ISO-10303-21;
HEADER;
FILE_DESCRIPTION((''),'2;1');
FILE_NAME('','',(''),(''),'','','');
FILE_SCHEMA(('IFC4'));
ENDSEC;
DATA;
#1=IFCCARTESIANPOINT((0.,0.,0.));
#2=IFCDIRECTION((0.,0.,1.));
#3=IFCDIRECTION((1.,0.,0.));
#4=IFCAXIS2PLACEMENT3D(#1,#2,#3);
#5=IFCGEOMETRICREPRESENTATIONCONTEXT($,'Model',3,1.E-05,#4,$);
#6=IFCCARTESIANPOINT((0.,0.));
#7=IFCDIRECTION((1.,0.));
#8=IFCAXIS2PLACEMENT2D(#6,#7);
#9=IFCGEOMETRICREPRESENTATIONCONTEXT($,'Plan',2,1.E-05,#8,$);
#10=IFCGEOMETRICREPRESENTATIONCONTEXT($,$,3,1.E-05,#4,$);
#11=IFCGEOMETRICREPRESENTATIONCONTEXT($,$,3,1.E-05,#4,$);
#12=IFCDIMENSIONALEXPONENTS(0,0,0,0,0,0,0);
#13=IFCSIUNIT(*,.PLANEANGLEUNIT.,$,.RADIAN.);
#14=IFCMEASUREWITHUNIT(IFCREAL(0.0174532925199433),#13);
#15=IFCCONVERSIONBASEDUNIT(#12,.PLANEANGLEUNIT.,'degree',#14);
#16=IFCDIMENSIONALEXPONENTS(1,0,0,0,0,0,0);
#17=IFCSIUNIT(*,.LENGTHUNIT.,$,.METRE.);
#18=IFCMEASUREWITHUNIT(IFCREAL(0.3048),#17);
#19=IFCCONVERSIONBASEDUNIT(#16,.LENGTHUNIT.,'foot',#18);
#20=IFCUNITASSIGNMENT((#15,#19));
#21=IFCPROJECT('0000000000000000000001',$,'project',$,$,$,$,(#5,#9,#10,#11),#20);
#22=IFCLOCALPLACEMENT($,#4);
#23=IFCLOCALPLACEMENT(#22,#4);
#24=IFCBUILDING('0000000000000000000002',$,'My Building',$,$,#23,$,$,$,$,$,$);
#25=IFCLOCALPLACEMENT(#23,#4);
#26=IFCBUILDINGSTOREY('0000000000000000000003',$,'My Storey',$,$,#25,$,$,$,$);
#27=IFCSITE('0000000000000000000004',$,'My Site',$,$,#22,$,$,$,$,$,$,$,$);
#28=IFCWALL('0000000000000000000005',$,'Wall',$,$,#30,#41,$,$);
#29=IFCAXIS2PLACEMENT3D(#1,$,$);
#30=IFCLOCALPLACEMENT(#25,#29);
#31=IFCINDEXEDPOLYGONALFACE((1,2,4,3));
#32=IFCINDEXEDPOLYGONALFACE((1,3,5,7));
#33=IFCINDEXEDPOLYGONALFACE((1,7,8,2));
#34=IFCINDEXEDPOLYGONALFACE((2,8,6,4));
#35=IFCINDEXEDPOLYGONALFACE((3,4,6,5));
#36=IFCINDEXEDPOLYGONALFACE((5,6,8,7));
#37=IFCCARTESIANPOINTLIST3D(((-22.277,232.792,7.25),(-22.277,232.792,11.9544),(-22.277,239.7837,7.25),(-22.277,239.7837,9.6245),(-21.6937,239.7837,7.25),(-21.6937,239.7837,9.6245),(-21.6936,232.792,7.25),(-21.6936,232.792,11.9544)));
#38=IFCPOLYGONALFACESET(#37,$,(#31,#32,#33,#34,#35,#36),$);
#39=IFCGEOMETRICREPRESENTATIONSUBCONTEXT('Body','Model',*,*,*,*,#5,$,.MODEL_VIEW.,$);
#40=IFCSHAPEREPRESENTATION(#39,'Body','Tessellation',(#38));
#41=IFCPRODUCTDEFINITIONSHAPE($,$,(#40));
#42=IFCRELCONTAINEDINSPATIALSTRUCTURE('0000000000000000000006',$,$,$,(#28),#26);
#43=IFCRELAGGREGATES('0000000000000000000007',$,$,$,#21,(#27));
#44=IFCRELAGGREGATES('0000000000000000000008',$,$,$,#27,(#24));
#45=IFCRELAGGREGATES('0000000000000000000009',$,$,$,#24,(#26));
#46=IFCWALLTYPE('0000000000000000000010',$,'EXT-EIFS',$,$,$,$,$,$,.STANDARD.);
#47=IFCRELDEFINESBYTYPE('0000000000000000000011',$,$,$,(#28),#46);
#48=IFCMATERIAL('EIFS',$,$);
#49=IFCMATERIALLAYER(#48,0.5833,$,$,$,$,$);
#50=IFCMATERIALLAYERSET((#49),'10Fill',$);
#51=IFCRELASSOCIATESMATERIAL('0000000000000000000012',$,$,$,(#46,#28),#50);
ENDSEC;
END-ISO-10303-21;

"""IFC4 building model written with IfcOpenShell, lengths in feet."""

from ifc_helpers import new_model, entity, si_unit, converted_unit, frame, origin_with_axes, origin_2d_with_axis, place, context, subcontext, project, spatial, indexed_curve, outline, extrude, clip, halfspace, material, layer, layer_set, layer_usage, type_object, element, save


model = new_model("IFC4")

# Units and contexts
model_context = context("Model", 3, precision=1e-05, world=origin_with_axes())
plan_context = context("Plan", 2, precision=1e-05, world=origin_2d_with_axis())
context_of_model_1 = context(None, 3, precision=1e-05, world=origin_with_axes())
context_of_model_2 = context(None, 3, precision=1e-05, world=origin_with_axes())
body_context = subcontext(model_context, "Body", "Model", "MODEL_VIEW")
ifc_project = project(units=[converted_unit("PLANEANGLEUNIT", "degree", entity("IfcReal", 0.0174532925199433), si_unit("PLANEANGLEUNIT", "RADIAN"), dimensions=[0, 0, 0, 0, 0, 0, 0]), converted_unit("LENGTHUNIT", "foot", entity("IfcReal", 0.3048), si_unit("LENGTHUNIT", "METRE"), dimensions=[1, 0, 0, 0, 0, 0, 0])], contexts=[model_context, plan_context, context_of_model_1, context_of_model_2])

# Site, building, storey
site_placement = place(None, origin_with_axes())
site = spatial("IfcSite", under=ifc_project, at=site_placement, Name="My Site")
building_placement = place(site_placement, origin_with_axes())
building = spatial("IfcBuilding", under=site, at=building_placement, Name="My Building")
storey_placement = place(building_placement, origin_with_axes())
storey = spatial("IfcBuildingStorey", under=building, at=storey_placement, Name="My Storey")

# Wall
ifc_material_1 = material(Name="EIFS")
ifc_layer_1 = layer(ifc_material_1, 0.5833)
ifc_layer_set_1 = layer_set([ifc_layer_1], Name="10Fill")
ifc_layer_usage_1 = layer_usage(ifc_layer_set_1, "AXIS2", "POSITIVE", 0.0)
wall_type_1 = type_object("IfcWallType", Name="EXT-EIFS", PredefinedType="STANDARD", material=ifc_layer_set_1)
wall_1_placement = place(storey_placement, frame((-22.277, 239.7837, 7.25), z_axis=(0.0, 0.0, 1.0), x_axis=(0.000001, -1.0, 0.0)))
element("IfcWall", 1, at=wall_1_placement, inside=storey, type_object=wall_type_1, material=ifc_layer_usage_1, Name="Wall", context=body_context, shape_type="Clipping", body=[
    clip(extrude(outline(indexed_curve([(0.0, 0.0), (0.0, 0.5833), (6.9917, 0.5833), (6.9917, 0.0), (0.0, 0.0)], self_intersect=False)), origin_with_axes(), (0.0, 0.0, 1.0), 11.9544), halfspace(frame((6.9917, 0.0, 4.7044), z_axis=(-0.316146, 0.0, 0.948711), x_axis=(0.0, -1.0, 0.0)), False)),
])

save(model, "model.ifc")
